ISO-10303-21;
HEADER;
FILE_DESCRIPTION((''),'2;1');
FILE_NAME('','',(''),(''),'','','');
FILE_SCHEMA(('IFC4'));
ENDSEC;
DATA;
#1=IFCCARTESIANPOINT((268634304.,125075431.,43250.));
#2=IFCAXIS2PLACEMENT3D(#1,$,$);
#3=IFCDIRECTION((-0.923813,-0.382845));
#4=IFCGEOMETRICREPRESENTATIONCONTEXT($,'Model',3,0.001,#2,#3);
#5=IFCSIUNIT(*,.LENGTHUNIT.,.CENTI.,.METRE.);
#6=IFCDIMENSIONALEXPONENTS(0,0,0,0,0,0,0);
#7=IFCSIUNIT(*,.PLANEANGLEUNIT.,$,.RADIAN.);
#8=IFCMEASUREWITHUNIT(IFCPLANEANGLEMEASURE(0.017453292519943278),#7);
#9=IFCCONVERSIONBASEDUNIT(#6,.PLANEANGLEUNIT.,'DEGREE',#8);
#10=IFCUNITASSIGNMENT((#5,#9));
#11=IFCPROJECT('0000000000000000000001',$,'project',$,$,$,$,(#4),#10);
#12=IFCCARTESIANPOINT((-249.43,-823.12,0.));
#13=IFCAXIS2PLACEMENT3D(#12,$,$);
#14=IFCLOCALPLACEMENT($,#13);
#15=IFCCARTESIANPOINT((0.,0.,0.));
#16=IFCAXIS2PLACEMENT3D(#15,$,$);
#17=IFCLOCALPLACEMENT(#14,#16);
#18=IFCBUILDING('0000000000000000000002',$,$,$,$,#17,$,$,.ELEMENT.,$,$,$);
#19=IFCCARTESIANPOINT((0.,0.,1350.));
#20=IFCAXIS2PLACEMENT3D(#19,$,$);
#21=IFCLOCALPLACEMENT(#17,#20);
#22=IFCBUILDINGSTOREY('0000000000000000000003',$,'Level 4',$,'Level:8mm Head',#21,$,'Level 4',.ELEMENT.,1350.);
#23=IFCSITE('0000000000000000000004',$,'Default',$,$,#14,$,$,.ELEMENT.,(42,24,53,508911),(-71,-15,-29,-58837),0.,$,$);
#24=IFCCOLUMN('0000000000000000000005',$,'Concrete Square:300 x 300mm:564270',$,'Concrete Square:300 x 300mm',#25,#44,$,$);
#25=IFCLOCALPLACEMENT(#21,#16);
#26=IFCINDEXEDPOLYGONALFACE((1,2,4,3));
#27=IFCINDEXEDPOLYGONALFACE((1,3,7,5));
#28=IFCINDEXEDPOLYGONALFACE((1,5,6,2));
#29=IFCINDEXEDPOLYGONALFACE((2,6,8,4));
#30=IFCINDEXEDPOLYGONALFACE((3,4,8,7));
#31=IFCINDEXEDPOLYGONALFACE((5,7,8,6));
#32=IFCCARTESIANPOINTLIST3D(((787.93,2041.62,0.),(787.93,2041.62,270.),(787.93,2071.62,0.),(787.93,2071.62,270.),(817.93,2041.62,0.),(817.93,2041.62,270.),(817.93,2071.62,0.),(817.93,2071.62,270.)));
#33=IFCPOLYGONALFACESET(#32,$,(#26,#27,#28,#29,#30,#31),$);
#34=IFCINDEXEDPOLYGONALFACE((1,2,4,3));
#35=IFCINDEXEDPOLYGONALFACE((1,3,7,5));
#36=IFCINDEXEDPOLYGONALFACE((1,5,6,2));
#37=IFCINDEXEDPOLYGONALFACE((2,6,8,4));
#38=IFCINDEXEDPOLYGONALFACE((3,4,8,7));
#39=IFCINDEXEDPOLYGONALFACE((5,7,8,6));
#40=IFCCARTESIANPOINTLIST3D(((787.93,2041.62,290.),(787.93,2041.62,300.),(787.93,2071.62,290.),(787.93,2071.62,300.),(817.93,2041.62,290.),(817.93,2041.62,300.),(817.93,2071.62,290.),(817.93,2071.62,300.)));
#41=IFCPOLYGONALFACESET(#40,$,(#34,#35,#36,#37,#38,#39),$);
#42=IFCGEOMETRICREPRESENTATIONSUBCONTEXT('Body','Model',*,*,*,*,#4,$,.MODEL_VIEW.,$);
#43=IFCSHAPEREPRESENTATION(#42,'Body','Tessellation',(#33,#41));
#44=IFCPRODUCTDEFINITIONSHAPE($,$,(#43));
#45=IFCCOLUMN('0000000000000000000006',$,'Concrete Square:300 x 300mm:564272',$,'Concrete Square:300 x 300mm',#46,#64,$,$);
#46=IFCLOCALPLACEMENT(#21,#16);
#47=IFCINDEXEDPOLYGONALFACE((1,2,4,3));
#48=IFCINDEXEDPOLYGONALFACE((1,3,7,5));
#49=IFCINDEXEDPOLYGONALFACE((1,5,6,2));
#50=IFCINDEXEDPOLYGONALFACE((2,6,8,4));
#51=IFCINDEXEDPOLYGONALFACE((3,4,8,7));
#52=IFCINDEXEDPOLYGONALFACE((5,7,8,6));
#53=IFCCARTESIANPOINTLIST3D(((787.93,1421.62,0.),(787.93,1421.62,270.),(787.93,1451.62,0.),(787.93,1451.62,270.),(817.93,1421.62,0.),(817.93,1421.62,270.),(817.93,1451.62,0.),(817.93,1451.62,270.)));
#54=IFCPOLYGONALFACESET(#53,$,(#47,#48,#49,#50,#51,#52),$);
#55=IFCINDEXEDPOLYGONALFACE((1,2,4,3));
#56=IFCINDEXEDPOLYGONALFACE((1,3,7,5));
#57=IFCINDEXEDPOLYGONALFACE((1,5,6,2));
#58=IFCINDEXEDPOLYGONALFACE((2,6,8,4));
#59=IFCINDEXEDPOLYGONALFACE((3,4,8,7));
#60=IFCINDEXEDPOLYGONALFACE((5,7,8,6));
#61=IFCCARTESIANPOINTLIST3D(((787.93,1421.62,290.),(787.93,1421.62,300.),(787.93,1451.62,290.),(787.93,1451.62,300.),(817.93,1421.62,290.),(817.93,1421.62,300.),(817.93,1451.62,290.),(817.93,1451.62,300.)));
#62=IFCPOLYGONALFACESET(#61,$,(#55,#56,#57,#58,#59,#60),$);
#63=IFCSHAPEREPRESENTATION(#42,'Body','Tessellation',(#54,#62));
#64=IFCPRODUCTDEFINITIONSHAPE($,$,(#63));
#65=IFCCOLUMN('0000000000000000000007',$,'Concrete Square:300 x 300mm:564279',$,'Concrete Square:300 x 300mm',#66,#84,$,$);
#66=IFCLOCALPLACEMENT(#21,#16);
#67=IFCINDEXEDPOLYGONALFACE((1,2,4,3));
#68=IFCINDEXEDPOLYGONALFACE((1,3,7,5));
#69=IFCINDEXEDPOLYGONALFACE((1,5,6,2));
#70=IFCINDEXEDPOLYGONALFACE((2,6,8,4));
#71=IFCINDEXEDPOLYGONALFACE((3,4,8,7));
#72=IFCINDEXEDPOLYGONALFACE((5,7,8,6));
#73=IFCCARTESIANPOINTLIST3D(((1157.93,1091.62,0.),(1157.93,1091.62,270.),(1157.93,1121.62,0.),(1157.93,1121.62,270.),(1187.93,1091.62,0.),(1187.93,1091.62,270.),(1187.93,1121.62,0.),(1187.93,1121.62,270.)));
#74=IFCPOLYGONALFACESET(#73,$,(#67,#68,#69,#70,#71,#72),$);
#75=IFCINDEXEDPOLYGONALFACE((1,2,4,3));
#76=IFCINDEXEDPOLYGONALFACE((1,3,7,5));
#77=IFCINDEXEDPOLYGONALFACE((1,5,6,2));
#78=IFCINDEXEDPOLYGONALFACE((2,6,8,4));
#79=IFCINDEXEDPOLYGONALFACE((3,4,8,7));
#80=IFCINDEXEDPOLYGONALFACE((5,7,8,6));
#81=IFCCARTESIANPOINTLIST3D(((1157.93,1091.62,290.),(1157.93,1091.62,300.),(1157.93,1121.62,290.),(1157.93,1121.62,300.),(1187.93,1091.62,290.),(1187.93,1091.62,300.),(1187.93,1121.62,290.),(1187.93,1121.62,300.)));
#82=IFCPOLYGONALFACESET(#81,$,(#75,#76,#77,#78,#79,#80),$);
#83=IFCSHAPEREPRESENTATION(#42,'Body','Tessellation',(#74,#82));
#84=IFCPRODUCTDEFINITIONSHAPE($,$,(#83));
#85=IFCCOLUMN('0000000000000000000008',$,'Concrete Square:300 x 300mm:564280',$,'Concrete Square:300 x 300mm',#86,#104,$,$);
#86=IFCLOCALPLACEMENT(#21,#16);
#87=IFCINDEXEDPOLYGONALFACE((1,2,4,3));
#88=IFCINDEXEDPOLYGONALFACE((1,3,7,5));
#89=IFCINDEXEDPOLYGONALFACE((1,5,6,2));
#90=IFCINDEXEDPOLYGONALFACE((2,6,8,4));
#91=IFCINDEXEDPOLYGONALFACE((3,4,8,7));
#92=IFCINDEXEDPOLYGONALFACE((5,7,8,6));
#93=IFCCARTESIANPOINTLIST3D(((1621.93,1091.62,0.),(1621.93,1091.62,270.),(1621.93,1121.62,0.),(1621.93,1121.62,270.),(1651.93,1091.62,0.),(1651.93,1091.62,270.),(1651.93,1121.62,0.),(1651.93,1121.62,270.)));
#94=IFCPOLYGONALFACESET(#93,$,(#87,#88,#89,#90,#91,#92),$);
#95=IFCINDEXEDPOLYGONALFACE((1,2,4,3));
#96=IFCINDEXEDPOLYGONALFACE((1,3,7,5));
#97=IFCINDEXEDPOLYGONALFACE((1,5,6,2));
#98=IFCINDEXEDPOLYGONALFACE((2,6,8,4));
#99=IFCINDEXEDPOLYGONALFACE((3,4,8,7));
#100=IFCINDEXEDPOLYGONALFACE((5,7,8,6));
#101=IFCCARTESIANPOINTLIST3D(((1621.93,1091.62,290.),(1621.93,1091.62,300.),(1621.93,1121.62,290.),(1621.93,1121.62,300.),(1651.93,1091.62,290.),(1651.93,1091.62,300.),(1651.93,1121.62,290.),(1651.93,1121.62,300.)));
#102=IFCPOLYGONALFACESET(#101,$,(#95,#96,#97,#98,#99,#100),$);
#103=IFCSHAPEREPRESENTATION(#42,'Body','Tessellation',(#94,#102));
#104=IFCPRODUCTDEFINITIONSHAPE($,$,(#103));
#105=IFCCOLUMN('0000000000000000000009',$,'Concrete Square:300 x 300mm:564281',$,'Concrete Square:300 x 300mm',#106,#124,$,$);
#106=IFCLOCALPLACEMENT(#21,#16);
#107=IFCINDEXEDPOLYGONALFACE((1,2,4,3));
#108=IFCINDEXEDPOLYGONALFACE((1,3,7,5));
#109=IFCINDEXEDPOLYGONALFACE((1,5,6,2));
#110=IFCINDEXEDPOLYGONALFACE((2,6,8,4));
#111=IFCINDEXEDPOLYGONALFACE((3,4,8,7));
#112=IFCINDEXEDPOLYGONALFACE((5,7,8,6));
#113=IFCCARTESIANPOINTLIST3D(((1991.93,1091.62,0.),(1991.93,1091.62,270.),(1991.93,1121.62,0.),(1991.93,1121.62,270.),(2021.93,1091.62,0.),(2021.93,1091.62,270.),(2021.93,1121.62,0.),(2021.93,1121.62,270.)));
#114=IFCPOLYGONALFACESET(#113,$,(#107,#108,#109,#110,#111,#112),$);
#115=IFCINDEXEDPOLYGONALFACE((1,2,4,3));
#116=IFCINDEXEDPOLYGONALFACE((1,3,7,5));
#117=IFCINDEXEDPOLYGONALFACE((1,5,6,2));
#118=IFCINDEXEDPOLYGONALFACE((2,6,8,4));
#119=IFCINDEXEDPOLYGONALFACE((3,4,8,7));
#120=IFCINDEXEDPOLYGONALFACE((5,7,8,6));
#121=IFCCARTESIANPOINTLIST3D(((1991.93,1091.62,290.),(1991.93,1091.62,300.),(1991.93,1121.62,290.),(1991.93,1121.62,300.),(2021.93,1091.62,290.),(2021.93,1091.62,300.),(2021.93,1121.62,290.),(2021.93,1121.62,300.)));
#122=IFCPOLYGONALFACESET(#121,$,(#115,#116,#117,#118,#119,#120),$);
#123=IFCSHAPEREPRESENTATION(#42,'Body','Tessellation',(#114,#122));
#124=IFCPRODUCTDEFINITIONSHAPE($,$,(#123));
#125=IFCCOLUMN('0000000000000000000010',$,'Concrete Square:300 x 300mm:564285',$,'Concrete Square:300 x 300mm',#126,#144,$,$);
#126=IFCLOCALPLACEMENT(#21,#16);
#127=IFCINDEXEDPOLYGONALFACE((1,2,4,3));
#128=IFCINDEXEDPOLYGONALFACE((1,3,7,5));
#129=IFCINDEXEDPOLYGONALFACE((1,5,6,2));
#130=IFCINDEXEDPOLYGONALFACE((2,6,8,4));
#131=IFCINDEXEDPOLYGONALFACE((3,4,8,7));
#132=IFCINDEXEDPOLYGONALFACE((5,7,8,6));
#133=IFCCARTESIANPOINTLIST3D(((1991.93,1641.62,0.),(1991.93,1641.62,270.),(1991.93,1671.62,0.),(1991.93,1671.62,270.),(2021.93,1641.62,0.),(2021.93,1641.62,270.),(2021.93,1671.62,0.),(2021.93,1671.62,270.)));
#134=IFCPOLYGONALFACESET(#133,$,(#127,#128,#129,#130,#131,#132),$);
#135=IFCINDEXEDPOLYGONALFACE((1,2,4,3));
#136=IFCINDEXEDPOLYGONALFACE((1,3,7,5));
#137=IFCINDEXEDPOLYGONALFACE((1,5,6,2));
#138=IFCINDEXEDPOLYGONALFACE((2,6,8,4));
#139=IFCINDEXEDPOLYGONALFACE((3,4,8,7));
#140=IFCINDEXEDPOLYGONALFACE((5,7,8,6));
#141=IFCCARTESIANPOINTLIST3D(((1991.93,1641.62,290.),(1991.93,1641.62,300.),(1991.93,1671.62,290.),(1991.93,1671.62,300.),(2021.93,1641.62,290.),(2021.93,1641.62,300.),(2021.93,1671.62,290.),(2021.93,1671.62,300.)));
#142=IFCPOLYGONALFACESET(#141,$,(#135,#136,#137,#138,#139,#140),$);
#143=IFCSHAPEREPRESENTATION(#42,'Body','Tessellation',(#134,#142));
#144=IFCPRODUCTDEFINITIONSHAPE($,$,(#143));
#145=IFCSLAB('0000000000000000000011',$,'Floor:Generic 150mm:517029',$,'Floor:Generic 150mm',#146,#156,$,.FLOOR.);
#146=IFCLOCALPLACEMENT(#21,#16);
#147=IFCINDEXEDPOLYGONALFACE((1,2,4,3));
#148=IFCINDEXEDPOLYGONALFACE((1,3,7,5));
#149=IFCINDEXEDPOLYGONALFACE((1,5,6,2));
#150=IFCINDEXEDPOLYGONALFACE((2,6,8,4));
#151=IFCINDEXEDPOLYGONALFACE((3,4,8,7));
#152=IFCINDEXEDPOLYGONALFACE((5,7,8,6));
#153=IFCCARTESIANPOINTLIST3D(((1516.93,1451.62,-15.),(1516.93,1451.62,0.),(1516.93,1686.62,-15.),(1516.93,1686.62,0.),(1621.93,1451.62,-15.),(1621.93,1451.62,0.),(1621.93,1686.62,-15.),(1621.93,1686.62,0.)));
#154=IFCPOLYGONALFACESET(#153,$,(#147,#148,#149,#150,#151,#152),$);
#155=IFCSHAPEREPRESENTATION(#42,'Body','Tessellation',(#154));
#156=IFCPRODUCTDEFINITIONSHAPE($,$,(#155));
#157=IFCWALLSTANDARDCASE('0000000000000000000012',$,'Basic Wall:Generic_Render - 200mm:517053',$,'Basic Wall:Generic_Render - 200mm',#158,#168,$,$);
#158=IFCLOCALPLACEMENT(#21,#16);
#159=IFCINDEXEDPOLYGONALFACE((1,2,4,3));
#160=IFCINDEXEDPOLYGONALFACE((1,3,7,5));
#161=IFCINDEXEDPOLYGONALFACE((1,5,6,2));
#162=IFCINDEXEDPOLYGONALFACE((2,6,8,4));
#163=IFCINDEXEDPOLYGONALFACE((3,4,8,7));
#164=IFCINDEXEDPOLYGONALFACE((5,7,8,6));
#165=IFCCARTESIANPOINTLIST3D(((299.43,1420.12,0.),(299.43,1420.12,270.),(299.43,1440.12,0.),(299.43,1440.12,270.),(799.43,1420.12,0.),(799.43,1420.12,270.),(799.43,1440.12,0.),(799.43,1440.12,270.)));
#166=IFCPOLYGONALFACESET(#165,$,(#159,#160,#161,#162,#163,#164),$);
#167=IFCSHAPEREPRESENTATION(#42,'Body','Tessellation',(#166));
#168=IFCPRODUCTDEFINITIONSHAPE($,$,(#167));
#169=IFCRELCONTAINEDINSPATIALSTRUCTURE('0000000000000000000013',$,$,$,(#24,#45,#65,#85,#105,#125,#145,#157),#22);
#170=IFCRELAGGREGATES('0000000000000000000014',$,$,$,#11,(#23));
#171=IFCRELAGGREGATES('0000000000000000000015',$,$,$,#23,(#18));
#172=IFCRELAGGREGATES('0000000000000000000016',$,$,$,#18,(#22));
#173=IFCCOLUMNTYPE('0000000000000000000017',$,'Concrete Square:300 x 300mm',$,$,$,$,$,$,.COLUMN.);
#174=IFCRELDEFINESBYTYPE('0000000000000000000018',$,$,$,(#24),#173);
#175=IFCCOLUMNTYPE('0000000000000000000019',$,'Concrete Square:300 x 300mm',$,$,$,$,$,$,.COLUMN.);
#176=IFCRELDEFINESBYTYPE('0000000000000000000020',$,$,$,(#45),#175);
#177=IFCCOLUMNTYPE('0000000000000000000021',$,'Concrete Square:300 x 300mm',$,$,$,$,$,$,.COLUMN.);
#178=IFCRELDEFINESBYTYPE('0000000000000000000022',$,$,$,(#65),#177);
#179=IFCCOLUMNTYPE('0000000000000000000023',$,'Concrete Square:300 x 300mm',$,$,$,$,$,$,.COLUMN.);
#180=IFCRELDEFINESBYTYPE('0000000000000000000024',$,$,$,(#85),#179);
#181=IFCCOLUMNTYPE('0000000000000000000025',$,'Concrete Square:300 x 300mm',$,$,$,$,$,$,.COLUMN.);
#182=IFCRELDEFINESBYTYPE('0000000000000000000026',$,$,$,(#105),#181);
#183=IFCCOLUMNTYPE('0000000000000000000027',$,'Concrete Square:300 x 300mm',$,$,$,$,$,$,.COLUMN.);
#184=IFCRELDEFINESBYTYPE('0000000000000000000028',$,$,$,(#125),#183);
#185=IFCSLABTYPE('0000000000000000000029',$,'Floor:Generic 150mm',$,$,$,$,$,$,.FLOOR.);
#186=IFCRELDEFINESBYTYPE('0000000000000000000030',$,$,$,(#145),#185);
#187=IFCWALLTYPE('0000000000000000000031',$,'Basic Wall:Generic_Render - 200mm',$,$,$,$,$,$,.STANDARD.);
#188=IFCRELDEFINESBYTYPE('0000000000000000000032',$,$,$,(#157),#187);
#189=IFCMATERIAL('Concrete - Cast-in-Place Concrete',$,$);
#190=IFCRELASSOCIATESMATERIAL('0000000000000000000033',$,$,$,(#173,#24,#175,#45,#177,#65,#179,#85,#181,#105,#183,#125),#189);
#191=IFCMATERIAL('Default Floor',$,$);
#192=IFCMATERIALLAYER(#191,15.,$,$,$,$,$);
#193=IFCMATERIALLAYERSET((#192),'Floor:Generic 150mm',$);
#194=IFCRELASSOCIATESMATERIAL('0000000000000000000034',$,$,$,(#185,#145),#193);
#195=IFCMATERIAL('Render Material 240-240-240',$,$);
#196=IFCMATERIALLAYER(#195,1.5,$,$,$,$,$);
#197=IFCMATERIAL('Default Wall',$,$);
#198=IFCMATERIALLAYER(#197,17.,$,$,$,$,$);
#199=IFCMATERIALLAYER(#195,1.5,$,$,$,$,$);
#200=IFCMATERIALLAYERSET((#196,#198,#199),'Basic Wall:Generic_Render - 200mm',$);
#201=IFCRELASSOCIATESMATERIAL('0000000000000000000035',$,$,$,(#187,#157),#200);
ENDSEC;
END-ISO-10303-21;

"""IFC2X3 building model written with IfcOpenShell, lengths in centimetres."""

from ifc_helpers import new_model, entity, si_unit, converted_unit, direction, frame, frame_2d, origin, origin_2d_with_axis, place, context, subcontext, project, spatial, rectangle, extrude, source, transform, mapped, material, layer, layer_set, layer_usage, type_object, type_shapes, element, save


model = new_model("IFC2X3")

# Units and contexts
model_context = context("Model", 3, precision=0.001, world=frame((268634304.0, 125075431.0, 43250.0)), true_north=direction((-0.923813, -0.382845)))
body_context = subcontext(model_context, "Body", "Model", "MODEL_VIEW")
ifc_project = project(units=[si_unit("LENGTHUNIT", "METRE", prefix="CENTI"), converted_unit("PLANEANGLEUNIT", "DEGREE", entity("IfcPlaneAngleMeasure", 0.017453292519943278), si_unit("PLANEANGLEUNIT", "RADIAN"), dimensions=[0, 0, 0, 0, 0, 0, 0])], contexts=[model_context])

# Site, building, storey
site_placement = place(None, frame((-249.43, -823.12, 0.0)))
site = spatial("IfcSite", under=ifc_project, at=site_placement, Name="Default", CompositionType="ELEMENT", RefLatitude=(42, 24, 53, 508911), RefLongitude=(-71, -15, -29, -58837), RefElevation=0.0)
building_placement = place(site_placement, origin())
building = spatial("IfcBuilding", under=site, at=building_placement, CompositionType="ELEMENT")
storey_placement = place(building_placement, frame((0.0, 0.0, 1350.0)))
storey = spatial("IfcBuildingStorey", under=building, at=storey_placement, Name="Level 4", ObjectType="Level:8mm Head", LongName="Level 4", CompositionType="ELEMENT", Elevation=1350.0)

# Columns
ifc_material_1 = material(Name="Concrete - Cast-in-Place Concrete")
column_type_1 = type_object("IfcColumnType", Name="Concrete Square:300 x 300mm", PredefinedType="COLUMN", material=ifc_material_1)
shared_shape_1 = source(origin(), body_context, "Body", "SweptSolid", [
    extrude(rectangle(XDim=30.0, YDim=30.0, at=frame_2d((0.0, 0.0), x_axis=(1.0, 0.0))), frame((802.93, 2056.62, 1350.0), z_axis=(0.0, 0.0, 1.0), x_axis=(-1.0, 0.0, 0.0)), (0.0, 0.0, 1.0), 270.0),
    extrude(rectangle(XDim=30.0, YDim=30.0, at=frame_2d((0.0, 0.0), x_axis=(1.0, 0.0))), frame((802.93, 2056.62, 1640.0), z_axis=(0.0, 0.0, 1.0), x_axis=(-1.0, 0.0, 0.0)), (0.0, 0.0, 1.0), 10.0),
])
type_shapes(column_type_1, [shared_shape_1])
column_1_placement = place(storey_placement, frame((0.0, 0.0, -1350.0)))
element("IfcColumn", 1, at=column_1_placement, inside=storey, type_object=column_type_1, material=ifc_material_1, Name="Concrete Square:300 x 300mm:564270", ObjectType="Concrete Square:300 x 300mm", context=body_context, shape_type="MappedRepresentation", body=[
    mapped(shared_shape_1, transform((0.0, 0.0, 0.0), scale=1.0)),
])
column_type_2 = type_object("IfcColumnType", Name="Concrete Square:300 x 300mm", PredefinedType="COLUMN", material=ifc_material_1)
shared_shape_2 = source(origin(), body_context, "Body", "SweptSolid", [
    extrude(rectangle(XDim=30.0, YDim=30.0, at=frame_2d((0.0, 0.0), x_axis=(1.0, 0.0))), frame((802.93, 1436.62, 1350.0), z_axis=(0.0, 0.0, 1.0), x_axis=(-1.0, 0.0, 0.0)), (0.0, 0.0, 1.0), 270.0),
    extrude(rectangle(XDim=30.0, YDim=30.0, at=frame_2d((0.0, 0.0), x_axis=(1.0, 0.0))), frame((802.93, 1436.62, 1640.0), z_axis=(0.0, 0.0, 1.0), x_axis=(-1.0, 0.0, 0.0)), (0.0, 0.0, 1.0), 10.0),
])
type_shapes(column_type_2, [shared_shape_2])
column_2_placement = place(storey_placement, frame((0.0, 0.0, -1350.0)))
element("IfcColumn", 2, at=column_2_placement, inside=storey, type_object=column_type_2, material=ifc_material_1, Name="Concrete Square:300 x 300mm:564272", ObjectType="Concrete Square:300 x 300mm", context=body_context, shape_type="MappedRepresentation", body=[
    mapped(shared_shape_2, transform((0.0, 0.0, 0.0), scale=1.0)),
])
column_type_3 = type_object("IfcColumnType", Name="Concrete Square:300 x 300mm", PredefinedType="COLUMN", material=ifc_material_1)
shared_shape_3 = source(origin(), body_context, "Body", "SweptSolid", [
    extrude(rectangle(XDim=30.0, YDim=30.0, at=frame_2d((0.0, 0.0), x_axis=(1.0, 0.0))), frame((1172.93, 1106.62, 1350.0), z_axis=(0.0, 0.0, 1.0), x_axis=(-1.0, 0.0, 0.0)), (0.0, 0.0, 1.0), 270.0),
    extrude(rectangle(XDim=30.0, YDim=30.0, at=origin_2d_with_axis()), frame((1172.93, 1106.62, 1640.0), z_axis=(0.0, 0.0, 1.0), x_axis=(-1.0, 0.0, 0.0)), (0.0, 0.0, 1.0), 10.0),
])
type_shapes(column_type_3, [shared_shape_3])
column_3_placement = place(storey_placement, frame((0.0, 0.0, -1350.0)))
element("IfcColumn", 3, at=column_3_placement, inside=storey, type_object=column_type_3, material=ifc_material_1, Name="Concrete Square:300 x 300mm:564279", ObjectType="Concrete Square:300 x 300mm", context=body_context, shape_type="MappedRepresentation", body=[
    mapped(shared_shape_3, transform((0.0, 0.0, 0.0), scale=1.0)),
])
column_type_4 = type_object("IfcColumnType", Name="Concrete Square:300 x 300mm", PredefinedType="COLUMN", material=ifc_material_1)
shared_shape_4 = source(origin(), body_context, "Body", "SweptSolid", [
    extrude(rectangle(XDim=30.0, YDim=30.0, at=frame_2d((0.0, 0.0), x_axis=(1.0, 0.0))), frame((1636.93, 1106.62, 1350.0), z_axis=(0.0, 0.0, 1.0), x_axis=(-1.0, 0.0, 0.0)), (0.0, 0.0, 1.0), 270.0),
    extrude(rectangle(XDim=30.0, YDim=30.0, at=origin_2d_with_axis()), frame((1636.93, 1106.62, 1640.0), z_axis=(0.0, 0.0, 1.0), x_axis=(-1.0, 0.0, 0.0)), (0.0, 0.0, 1.0), 10.0),
])
type_shapes(column_type_4, [shared_shape_4])
column_4_placement = place(storey_placement, frame((0.0, 0.0, -1350.0)))
element("IfcColumn", 4, at=column_4_placement, inside=storey, type_object=column_type_4, material=ifc_material_1, Name="Concrete Square:300 x 300mm:564280", ObjectType="Concrete Square:300 x 300mm", context=body_context, shape_type="MappedRepresentation", body=[
    mapped(shared_shape_4, transform((0.0, 0.0, 0.0), scale=1.0)),
])
column_type_5 = type_object("IfcColumnType", Name="Concrete Square:300 x 300mm", PredefinedType="COLUMN", material=ifc_material_1)
shared_shape_5 = source(origin(), body_context, "Body", "SweptSolid", [
    extrude(rectangle(XDim=30.0, YDim=30.0, at=frame_2d((0.0, 0.0), x_axis=(1.0, 0.0))), frame((2006.93, 1106.62, 1350.0), z_axis=(0.0, 0.0, 1.0), x_axis=(-1.0, 0.0, 0.0)), (0.0, 0.0, 1.0), 270.0),
    extrude(rectangle(XDim=30.0, YDim=30.0, at=origin_2d_with_axis()), frame((2006.93, 1106.62, 1640.0), z_axis=(0.0, 0.0, 1.0), x_axis=(-1.0, 0.0, 0.0)), (0.0, 0.0, 1.0), 10.0),
])
type_shapes(column_type_5, [shared_shape_5])
column_5_placement = place(storey_placement, frame((0.0, 0.0, -1350.0)))
element("IfcColumn", 5, at=column_5_placement, inside=storey, type_object=column_type_5, material=ifc_material_1, Name="Concrete Square:300 x 300mm:564281", ObjectType="Concrete Square:300 x 300mm", context=body_context, shape_type="MappedRepresentation", body=[
    mapped(shared_shape_5, transform((0.0, 0.0, 0.0), scale=1.0)),
])
column_type_6 = type_object("IfcColumnType", Name="Concrete Square:300 x 300mm", PredefinedType="COLUMN", material=ifc_material_1)
shared_shape_6 = source(origin(), body_context, "Body", "SweptSolid", [
    extrude(rectangle(XDim=30.0, YDim=30.0, at=frame_2d((0.0, 0.0), x_axis=(1.0, 0.0))), frame((2006.93, 1656.62, 1350.0), z_axis=(0.0, 0.0, 1.0), x_axis=(-1.0, 0.0, 0.0)), (0.0, 0.0, 1.0), 270.0),
    extrude(rectangle(XDim=30.0, YDim=30.0, at=origin_2d_with_axis()), frame((2006.93, 1656.62, 1640.0), z_axis=(0.0, 0.0, 1.0), x_axis=(-1.0, 0.0, 0.0)), (0.0, 0.0, 1.0), 10.0),
])
type_shapes(column_type_6, [shared_shape_6])
column_6_placement = place(storey_placement, frame((0.0, 0.0, -1350.0)))
element("IfcColumn", 6, at=column_6_placement, inside=storey, type_object=column_type_6, material=ifc_material_1, Name="Concrete Square:300 x 300mm:564285", ObjectType="Concrete Square:300 x 300mm", context=body_context, shape_type="MappedRepresentation", body=[
    mapped(shared_shape_6, transform((0.0, 0.0, 0.0), scale=1.0)),
])

# Slab
ifc_material_2 = material(Name="Default Floor")
ifc_layer_1 = layer(ifc_material_2, 15.0)
ifc_layer_set_1 = layer_set([ifc_layer_1], Name="Floor:Generic 150mm")
ifc_layer_usage_1 = layer_usage(ifc_layer_set_1, "AXIS3", "POSITIVE", 0.0)
slab_type_1 = type_object("IfcSlabType", Name="Floor:Generic 150mm", PredefinedType="FLOOR", material=ifc_layer_set_1)
slab_1_placement = place(storey_placement, origin())
element("IfcSlab", 7, at=slab_1_placement, inside=storey, type_object=slab_type_1, material=ifc_layer_usage_1, Name="Floor:Generic 150mm:517029", ObjectType="Floor:Generic 150mm", PredefinedType="FLOOR", context=body_context, shape_type="SweptSolid", body=[
    extrude(rectangle(XDim=235.0, YDim=105.0, at=origin_2d_with_axis()), frame((1569.43, 1569.12, 0.0), z_axis=(0.0, 0.0, -1.0), x_axis=(0.0, 1.0, 0.0)), (0.0, 0.0, 1.0), 15.0),
])

# Wall
ifc_material_3 = material(Name="Render Material 240-240-240")
ifc_layer_2 = layer(ifc_material_3, 1.5)
ifc_material_4 = material(Name="Default Wall")
ifc_layer_3 = layer(ifc_material_4, 17.0)
ifc_layer_4 = layer(ifc_material_3, 1.5)
ifc_layer_set_2 = layer_set([ifc_layer_2, ifc_layer_3, ifc_layer_4], Name="Basic Wall:Generic_Render - 200mm")
ifc_layer_usage_2 = layer_usage(ifc_layer_set_2, "AXIS2", "NEGATIVE", 10.0)
wall_type_1 = type_object("IfcWallType", Name="Basic Wall:Generic_Render - 200mm", PredefinedType="STANDARD", material=ifc_layer_set_2)
wall_1_placement = place(storey_placement, frame((799.43, 1430.12, 0.0), z_axis=(0.0, 0.0, 1.0), x_axis=(-1.0, 0.0, 0.0)))
element("IfcWallStandardCase", 8, at=wall_1_placement, inside=storey, type_object=wall_type_1, material=ifc_layer_usage_2, Name="Basic Wall:Generic_Render - 200mm:517053", ObjectType="Basic Wall:Generic_Render - 200mm", context=body_context, shape_type="SweptSolid", body=[
    extrude(rectangle(XDim=500.0, YDim=20.0, at=frame_2d((250.0, 0.0), x_axis=(-1.0, 0.0))), origin(), (0.0, 0.0, 1.0), 270.0),
])

save(model, "model.ifc")
